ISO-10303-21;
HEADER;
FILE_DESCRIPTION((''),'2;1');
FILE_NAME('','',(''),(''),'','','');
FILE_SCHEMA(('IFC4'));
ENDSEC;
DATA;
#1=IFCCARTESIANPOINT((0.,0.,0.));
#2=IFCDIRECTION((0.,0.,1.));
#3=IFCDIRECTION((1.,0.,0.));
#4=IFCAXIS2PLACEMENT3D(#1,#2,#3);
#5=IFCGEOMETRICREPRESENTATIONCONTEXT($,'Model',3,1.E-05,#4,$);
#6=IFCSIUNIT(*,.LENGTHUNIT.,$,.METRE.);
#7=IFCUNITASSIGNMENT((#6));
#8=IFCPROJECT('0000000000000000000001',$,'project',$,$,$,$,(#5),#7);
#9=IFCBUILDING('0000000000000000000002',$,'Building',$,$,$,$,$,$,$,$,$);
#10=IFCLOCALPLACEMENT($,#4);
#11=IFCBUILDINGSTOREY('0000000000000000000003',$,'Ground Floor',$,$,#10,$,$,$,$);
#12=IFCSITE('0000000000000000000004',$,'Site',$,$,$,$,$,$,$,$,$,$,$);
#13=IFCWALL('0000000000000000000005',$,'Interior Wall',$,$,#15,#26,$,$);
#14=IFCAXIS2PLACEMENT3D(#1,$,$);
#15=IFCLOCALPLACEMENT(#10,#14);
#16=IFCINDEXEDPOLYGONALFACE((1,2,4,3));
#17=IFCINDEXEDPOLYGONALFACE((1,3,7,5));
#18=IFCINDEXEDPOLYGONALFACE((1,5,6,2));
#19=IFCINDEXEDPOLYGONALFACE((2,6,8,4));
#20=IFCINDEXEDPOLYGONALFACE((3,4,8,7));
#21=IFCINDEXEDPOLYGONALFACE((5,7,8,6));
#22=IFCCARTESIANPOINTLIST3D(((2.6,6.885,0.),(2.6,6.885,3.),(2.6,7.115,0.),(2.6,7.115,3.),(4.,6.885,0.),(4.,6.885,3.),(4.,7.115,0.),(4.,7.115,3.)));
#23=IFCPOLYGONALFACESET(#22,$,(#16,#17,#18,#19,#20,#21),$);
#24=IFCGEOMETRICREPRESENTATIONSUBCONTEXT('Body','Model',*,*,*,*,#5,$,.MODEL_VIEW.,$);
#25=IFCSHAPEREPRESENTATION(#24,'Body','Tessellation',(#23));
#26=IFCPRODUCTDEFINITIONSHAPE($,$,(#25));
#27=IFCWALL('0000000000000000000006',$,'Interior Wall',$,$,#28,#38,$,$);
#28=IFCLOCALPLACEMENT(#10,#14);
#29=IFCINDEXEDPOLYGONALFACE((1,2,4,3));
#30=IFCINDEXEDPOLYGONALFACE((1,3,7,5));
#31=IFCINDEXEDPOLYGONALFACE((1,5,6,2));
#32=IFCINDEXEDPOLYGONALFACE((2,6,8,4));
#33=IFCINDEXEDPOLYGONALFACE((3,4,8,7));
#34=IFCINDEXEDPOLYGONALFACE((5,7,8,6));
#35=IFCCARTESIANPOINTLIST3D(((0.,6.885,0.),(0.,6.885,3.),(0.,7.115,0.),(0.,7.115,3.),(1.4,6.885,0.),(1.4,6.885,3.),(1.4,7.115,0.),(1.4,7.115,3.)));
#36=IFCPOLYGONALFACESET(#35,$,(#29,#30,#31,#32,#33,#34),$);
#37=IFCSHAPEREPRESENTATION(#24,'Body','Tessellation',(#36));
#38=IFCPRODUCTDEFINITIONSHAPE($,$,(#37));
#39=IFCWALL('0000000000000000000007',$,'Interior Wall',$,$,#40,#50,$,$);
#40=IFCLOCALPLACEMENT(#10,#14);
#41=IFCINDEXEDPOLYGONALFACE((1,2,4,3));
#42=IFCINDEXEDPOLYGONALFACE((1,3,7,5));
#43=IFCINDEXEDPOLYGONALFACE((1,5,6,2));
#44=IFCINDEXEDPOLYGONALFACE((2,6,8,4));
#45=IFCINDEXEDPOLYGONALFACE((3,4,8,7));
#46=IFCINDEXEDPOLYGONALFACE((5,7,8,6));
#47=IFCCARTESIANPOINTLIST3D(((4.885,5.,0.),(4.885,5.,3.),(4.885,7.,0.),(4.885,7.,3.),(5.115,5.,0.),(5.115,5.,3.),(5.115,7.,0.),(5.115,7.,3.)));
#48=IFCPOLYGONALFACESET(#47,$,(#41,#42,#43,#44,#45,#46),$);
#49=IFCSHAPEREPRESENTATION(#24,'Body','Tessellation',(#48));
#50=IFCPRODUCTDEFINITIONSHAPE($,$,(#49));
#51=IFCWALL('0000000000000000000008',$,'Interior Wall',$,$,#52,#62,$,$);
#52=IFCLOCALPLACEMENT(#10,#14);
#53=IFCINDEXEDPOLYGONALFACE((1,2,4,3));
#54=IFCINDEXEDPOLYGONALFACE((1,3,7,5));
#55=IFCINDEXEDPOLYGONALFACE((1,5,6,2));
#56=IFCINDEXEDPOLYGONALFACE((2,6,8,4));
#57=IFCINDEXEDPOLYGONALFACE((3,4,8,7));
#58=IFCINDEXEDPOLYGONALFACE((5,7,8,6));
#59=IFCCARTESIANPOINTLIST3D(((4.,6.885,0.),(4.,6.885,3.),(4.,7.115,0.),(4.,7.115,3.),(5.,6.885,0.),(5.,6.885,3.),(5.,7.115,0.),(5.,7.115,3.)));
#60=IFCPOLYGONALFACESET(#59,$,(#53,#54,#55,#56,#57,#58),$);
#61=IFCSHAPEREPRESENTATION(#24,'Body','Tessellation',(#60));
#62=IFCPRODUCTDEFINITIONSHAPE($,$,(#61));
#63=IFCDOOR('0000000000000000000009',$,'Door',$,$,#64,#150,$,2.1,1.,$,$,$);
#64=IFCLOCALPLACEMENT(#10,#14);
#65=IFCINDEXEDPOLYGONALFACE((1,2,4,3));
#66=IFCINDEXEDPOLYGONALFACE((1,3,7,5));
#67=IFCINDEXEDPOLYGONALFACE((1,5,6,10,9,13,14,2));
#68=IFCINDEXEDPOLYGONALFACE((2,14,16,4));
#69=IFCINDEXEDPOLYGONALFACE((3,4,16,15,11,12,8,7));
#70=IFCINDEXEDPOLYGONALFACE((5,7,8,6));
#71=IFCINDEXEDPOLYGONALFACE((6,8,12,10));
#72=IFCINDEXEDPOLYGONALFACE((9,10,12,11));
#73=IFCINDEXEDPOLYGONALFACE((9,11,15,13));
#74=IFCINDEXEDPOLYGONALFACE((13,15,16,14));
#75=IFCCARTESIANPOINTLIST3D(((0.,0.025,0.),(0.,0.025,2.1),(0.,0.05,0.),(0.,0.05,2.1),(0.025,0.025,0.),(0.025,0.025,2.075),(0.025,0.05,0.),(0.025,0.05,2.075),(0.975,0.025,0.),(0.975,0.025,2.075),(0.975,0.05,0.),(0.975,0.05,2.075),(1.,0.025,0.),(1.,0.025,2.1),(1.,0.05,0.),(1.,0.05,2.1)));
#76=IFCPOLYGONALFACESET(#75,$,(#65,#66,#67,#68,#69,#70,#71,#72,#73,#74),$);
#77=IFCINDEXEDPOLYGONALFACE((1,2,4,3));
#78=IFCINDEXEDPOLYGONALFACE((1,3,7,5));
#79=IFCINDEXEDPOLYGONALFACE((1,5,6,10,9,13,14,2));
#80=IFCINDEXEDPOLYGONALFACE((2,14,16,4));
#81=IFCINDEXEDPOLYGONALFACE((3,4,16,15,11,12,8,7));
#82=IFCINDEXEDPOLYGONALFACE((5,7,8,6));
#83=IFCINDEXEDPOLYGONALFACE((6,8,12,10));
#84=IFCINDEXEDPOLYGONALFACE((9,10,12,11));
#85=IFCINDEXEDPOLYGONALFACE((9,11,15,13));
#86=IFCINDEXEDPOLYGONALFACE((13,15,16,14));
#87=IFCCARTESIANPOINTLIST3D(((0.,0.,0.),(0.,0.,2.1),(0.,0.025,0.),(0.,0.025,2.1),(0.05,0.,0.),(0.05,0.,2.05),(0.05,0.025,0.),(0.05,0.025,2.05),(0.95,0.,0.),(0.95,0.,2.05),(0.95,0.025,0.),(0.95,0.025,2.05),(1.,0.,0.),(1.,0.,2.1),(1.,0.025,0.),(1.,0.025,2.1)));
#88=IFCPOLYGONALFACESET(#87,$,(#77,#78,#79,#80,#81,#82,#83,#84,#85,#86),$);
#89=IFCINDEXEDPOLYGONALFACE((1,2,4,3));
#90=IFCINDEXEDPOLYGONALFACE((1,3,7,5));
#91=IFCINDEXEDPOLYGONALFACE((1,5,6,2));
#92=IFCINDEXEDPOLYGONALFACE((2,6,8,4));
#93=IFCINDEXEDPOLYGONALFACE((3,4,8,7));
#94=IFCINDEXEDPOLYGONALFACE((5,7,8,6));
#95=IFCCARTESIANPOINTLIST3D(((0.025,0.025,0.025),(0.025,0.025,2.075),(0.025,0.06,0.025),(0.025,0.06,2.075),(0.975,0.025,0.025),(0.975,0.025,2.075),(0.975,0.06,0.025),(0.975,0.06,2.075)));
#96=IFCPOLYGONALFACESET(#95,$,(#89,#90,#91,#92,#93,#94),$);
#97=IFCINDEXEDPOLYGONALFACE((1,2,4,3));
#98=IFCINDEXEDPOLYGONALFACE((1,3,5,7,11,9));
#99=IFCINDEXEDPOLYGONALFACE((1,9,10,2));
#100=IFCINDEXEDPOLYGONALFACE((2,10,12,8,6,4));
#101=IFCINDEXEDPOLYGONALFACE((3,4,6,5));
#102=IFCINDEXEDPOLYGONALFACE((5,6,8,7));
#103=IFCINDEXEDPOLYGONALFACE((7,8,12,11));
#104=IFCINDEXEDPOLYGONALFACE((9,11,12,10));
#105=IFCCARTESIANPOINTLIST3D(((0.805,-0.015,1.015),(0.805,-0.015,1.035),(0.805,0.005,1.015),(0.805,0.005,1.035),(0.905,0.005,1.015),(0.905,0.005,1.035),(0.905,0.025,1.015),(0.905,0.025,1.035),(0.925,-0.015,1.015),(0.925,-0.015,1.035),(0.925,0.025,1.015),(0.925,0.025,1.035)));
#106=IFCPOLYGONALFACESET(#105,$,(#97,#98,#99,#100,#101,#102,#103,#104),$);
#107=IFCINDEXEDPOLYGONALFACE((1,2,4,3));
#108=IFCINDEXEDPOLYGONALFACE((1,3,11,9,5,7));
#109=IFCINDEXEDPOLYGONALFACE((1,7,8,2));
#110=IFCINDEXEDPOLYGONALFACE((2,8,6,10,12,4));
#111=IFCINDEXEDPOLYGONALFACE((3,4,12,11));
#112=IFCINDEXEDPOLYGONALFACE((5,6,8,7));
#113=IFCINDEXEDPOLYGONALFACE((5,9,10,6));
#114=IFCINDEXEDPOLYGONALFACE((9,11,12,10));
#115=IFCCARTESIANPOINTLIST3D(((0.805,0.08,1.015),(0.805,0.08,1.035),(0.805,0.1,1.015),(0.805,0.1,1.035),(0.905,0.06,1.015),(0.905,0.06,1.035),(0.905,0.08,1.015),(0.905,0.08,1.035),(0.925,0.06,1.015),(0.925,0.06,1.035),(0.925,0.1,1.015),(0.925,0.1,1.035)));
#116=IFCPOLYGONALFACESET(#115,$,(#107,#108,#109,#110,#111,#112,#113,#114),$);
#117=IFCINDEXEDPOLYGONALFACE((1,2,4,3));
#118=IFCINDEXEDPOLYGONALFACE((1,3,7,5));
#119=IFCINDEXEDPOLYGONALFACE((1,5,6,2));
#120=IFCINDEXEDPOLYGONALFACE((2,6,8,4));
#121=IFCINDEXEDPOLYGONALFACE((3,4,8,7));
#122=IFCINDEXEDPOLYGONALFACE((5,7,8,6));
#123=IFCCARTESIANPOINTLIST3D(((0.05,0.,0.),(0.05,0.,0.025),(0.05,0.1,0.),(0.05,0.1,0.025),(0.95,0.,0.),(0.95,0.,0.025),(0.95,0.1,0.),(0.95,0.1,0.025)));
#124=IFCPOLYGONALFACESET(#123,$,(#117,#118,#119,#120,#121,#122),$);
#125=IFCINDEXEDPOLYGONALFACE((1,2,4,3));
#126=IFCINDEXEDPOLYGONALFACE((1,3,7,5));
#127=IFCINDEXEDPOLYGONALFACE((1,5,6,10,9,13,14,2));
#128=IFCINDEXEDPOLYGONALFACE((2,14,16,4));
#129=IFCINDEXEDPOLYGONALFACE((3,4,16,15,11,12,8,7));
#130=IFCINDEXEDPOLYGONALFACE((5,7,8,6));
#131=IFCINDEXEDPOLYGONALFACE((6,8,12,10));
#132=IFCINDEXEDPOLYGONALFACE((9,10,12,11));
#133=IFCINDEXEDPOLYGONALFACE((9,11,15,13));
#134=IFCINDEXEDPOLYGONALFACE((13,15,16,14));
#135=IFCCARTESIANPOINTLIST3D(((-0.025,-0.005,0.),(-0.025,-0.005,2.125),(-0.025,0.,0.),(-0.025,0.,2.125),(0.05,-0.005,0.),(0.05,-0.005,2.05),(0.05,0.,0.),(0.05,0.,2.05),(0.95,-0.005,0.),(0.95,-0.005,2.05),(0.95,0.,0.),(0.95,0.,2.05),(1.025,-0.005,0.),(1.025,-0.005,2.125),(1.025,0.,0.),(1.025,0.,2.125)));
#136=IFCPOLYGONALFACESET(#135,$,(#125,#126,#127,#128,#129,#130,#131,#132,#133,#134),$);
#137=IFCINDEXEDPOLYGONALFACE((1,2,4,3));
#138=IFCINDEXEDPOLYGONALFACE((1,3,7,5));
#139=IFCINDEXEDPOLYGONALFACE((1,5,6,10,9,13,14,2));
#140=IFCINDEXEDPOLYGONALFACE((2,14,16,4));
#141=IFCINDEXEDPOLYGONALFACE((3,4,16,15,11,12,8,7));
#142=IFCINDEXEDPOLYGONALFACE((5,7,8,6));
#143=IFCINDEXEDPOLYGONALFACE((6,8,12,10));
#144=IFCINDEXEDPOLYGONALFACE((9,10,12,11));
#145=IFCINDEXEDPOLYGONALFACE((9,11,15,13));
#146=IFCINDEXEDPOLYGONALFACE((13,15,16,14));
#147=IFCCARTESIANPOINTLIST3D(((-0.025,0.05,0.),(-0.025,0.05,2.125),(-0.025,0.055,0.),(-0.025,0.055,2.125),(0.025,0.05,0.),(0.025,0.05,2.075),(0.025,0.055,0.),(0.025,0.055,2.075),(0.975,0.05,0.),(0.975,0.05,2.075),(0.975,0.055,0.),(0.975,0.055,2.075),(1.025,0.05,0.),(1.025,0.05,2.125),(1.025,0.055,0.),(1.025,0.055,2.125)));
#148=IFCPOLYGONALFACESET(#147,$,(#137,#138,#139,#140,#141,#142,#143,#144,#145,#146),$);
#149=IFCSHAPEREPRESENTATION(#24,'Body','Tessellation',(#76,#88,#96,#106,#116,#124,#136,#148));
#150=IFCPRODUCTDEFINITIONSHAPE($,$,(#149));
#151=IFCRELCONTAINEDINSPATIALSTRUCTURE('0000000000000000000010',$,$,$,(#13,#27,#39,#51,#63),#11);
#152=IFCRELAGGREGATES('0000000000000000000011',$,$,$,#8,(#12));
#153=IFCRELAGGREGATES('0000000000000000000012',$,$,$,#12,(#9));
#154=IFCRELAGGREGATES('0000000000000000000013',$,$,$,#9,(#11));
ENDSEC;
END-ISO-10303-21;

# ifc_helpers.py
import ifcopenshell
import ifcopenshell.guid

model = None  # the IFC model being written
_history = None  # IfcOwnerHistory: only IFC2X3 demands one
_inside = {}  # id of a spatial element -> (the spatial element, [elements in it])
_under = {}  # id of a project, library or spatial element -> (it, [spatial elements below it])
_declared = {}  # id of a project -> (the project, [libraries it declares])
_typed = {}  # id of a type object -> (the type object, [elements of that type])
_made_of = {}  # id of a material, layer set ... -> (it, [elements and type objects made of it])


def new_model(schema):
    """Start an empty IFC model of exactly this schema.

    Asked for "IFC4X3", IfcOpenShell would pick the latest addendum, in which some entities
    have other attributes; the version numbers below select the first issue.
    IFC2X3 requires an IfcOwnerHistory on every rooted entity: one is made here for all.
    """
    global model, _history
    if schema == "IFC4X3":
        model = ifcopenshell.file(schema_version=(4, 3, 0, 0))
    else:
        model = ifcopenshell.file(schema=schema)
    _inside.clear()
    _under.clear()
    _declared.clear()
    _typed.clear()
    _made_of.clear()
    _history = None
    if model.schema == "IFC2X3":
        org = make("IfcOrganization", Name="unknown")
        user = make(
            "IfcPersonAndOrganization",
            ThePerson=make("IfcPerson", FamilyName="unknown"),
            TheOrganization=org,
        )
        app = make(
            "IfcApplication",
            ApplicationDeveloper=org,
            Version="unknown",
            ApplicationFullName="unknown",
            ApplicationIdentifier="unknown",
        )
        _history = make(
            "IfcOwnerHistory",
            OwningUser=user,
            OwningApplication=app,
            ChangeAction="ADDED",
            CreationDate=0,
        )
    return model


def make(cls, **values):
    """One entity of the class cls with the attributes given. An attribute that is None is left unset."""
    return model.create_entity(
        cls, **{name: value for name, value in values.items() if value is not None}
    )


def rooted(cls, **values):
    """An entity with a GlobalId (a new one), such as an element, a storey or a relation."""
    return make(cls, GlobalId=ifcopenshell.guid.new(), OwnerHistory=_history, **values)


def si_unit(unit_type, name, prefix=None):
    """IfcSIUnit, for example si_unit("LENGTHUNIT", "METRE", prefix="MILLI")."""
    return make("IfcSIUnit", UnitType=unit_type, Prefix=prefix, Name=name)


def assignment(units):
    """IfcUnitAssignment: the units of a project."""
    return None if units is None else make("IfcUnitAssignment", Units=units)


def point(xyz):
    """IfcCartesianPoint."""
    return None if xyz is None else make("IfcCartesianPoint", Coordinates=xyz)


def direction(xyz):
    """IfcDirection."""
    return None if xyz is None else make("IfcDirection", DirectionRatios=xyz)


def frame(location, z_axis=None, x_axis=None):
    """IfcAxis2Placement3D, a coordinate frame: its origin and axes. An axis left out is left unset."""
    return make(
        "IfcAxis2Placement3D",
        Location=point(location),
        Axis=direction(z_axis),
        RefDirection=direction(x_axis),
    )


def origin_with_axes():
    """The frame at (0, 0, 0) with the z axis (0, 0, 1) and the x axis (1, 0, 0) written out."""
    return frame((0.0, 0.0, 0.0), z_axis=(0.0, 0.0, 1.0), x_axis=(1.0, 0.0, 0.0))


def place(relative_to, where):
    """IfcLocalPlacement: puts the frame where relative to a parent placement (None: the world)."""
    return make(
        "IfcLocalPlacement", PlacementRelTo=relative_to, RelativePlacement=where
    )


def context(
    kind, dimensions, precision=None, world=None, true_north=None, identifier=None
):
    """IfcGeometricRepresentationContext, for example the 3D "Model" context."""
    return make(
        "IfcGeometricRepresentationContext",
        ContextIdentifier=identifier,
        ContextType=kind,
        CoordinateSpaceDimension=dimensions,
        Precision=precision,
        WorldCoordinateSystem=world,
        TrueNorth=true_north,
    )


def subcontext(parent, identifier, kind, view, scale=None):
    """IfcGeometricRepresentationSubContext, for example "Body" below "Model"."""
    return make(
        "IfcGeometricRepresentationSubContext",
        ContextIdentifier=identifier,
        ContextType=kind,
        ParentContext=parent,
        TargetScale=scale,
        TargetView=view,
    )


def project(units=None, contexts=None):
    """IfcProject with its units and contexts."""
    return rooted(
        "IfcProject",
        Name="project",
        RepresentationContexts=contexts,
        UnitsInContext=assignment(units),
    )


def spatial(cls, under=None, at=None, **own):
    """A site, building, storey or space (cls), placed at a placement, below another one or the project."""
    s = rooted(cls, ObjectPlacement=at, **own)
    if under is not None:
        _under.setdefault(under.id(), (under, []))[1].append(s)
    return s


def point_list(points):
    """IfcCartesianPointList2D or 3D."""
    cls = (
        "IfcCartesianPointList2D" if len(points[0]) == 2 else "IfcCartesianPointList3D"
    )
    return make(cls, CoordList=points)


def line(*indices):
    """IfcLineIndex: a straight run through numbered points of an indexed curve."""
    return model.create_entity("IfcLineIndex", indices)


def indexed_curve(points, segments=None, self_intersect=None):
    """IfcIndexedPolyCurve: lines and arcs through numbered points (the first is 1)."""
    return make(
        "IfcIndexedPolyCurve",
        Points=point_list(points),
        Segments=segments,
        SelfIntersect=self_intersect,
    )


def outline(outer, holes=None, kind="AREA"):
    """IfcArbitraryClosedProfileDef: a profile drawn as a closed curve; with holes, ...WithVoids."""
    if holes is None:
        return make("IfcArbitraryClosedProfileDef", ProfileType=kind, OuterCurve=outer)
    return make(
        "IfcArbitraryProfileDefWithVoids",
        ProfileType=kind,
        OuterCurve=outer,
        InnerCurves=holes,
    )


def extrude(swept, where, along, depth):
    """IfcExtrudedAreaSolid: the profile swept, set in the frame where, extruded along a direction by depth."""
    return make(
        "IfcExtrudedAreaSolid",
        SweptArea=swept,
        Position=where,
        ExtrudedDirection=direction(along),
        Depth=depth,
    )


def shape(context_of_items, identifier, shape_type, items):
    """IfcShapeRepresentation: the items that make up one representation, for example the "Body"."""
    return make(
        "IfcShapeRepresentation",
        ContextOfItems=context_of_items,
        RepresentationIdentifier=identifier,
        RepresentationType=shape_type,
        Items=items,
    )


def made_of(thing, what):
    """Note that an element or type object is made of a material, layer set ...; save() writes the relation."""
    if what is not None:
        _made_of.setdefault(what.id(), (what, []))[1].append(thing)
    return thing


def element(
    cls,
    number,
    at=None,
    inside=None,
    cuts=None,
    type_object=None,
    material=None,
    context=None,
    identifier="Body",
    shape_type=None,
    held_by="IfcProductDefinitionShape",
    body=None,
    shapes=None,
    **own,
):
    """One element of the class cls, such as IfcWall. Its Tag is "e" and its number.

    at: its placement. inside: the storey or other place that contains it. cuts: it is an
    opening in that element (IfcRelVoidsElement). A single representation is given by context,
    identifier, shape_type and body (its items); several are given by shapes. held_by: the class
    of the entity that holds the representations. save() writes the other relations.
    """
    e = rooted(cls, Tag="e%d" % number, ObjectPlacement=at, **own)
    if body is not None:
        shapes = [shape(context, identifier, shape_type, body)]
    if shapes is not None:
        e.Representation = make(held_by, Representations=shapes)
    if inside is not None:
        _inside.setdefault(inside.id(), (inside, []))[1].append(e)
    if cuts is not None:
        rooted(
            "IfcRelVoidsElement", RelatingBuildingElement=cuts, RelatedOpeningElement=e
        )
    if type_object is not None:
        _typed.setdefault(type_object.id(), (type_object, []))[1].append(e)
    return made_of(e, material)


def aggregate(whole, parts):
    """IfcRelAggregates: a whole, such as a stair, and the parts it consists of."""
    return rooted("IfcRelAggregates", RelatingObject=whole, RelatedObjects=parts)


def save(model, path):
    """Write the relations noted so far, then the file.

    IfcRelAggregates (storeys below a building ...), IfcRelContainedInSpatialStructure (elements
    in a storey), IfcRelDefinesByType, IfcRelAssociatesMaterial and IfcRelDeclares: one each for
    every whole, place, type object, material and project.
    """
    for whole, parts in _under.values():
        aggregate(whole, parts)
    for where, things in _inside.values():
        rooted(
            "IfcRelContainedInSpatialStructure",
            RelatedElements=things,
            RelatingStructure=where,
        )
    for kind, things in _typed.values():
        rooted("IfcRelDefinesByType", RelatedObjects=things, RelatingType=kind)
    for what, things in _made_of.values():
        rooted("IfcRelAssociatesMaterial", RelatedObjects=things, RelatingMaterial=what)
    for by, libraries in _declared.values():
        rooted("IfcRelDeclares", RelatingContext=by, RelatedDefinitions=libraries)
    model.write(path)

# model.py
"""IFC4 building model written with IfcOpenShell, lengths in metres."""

from ifc_helpers import new_model, si_unit, frame, origin_with_axes, place, context, subcontext, project, spatial, line, indexed_curve, outline, extrude, element, save


model = new_model("IFC4")

# Units and contexts
model_context = context("Model", 3, precision=1e-05, world=origin_with_axes())
body_context = subcontext(model_context, "Body", "Model", "MODEL_VIEW")
ifc_project = project(units=[si_unit("LENGTHUNIT", "METRE")], contexts=[model_context])

# Site, building, storey
site = spatial("IfcSite", under=ifc_project, Name="Site")
building = spatial("IfcBuilding", under=site, Name="Building")
storey_placement = place(None, origin_with_axes())
storey = spatial("IfcBuildingStorey", under=building, at=storey_placement, Name="Ground Floor")

# Walls
for number, where, z_axis, x_axis, name in (
    (1, (4.0, 7.0, 0.0), (0.0, 0.0, 1.0), (-1.0, 0.0, 0.0), "Interior Wall"),
    (2, (1.4, 7.0, 0.0), (0.0, 0.0, 1.0), (-1.0, 0.0, 0.0), "Interior Wall"),
):
    element("IfcWall", number, at=place(storey_placement, frame(where, z_axis=z_axis, x_axis=x_axis)), inside=storey, Name=name, context=body_context, shape_type="SweptSolid", body=[
        extrude(outline(indexed_curve([(0.0, 0.0), (0.0, 0.23), (1.4, 0.23), (1.4, 0.0), (0.0, 0.0)], self_intersect=False)), frame((0.0, -0.115, 0.0), z_axis=(0.0, 0.0, 1.0), x_axis=(1.0, 0.0, 0.0)), (0.0, 0.0, 1.0), 3.0),
    ])
wall_1_placement = place(storey_placement, frame((5.0, 5.0, 0.0), z_axis=(0.0, 0.0, 1.0), x_axis=(0.0, 1.0, 0.0)))
element("IfcWall", 3, at=wall_1_placement, inside=storey, Name="Interior Wall", context=body_context, shape_type="SweptSolid", body=[
    extrude(outline(indexed_curve([(0.0, 0.0), (0.0, 0.23), (2.0, 0.23), (2.0, 0.0), (0.0, 0.0)], self_intersect=False)), frame((0.0, -0.115, 0.0), z_axis=(0.0, 0.0, 1.0), x_axis=(1.0, 0.0, 0.0)), (0.0, 0.0, 1.0), 3.0),
])
wall_2_placement = place(storey_placement, frame((5.0, 7.0, 0.0), z_axis=(0.0, 0.0, 1.0), x_axis=(-1.0, 0.0, 0.0)))
element("IfcWall", 4, at=wall_2_placement, inside=storey, Name="Interior Wall", context=body_context, shape_type="SweptSolid", body=[
    extrude(outline(indexed_curve([(0.0, 0.0), (0.0, 0.23), (1.0, 0.23), (1.0, 0.0), (0.0, 0.0)], self_intersect=False)), frame((0.0, -0.115, 0.0), z_axis=(0.0, 0.0, 1.0), x_axis=(1.0, 0.0, 0.0)), (0.0, 0.0, 1.0), 3.0),
])

# Door
door_1_placement = place(storey_placement, origin_with_axes())
element("IfcDoor", 5, at=door_1_placement, inside=storey, Name="Door", OverallHeight=2.1, OverallWidth=1.0, context=body_context, shape_type="SweptSolid", body=[
    extrude(outline(indexed_curve([(0.0, 0.0), (0.0, 2.1), (1.0, 2.1), (1.0, 0.0), (0.975, 0.0), (0.975, 2.075), (0.025, 2.075), (0.025, 0.0)], segments=[line(1, 2, 3, 4, 5, 6, 7, 8, 1)])), frame((0.0, 0.025, 0.0), z_axis=(0.0, -1.0, 0.0), x_axis=(1.0, 0.0, 0.0)), (0.0, 0.0, -1.0), 0.025),
    extrude(outline(indexed_curve([(0.0, 0.0), (0.0, 2.1), (1.0, 2.1), (1.0, 0.0), (0.95, 0.0), (0.95, 2.05), (0.05, 2.05), (0.05, 0.0)], segments=[line(1, 2, 3, 4, 5, 6, 7, 8, 1)])), frame((0.0, 0.0, 0.0), z_axis=(0.0, -1.0, 0.0), x_axis=(1.0, 0.0, 0.0)), (0.0, 0.0, -1.0), 0.025),
    extrude(outline(indexed_curve([(0.0, 0.0), (0.95, 0.0), (0.95, 0.035), (0.0, 0.035)], segments=[line(1, 2, 3, 4, 1)])), frame((0.025, 0.025, 0.025), z_axis=(0.0, 0.0, 1.0), x_axis=(1.0, 0.0, 0.0)), (0.0, 0.0, 1.0), 2.05),
    extrude(outline(indexed_curve([(0.0, 0.0), (0.0, -0.04), (-0.12, -0.04), (-0.12, -0.02), (-0.02, -0.02), (-0.02, 0.0)], segments=[line(1, 2, 3, 4, 5, 6, 1)])), frame((0.925, 0.025, 1.015), z_axis=(0.0, 0.0, 1.0), x_axis=(1.0, 0.0, 0.0)), (0.0, 0.0, 1.0), 0.02),
    extrude(outline(indexed_curve([(0.0, 0.0), (0.0, 0.04), (-0.12, 0.04), (-0.12, 0.02), (-0.02, 0.02), (-0.02, 0.0)], segments=[line(1, 2, 3, 4, 5, 6, 1)])), frame((0.925, 0.06, 1.015), z_axis=(0.0, 0.0, 1.0), x_axis=(1.0, 0.0, 0.0)), (0.0, 0.0, 1.0), 0.02),
    extrude(outline(indexed_curve([(0.0, 0.0), (0.9, 0.0), (0.9, 0.1), (0.0, 0.1)], segments=[line(1, 2, 3, 4, 1)])), frame((0.05, 0.0, 0.0), z_axis=(0.0, 0.0, 1.0), x_axis=(1.0, 0.0, 0.0)), (0.0, 0.0, 1.0), 0.025),
    extrude(outline(indexed_curve([(0.0, 0.0), (0.0, 2.125), (1.05, 2.125), (1.05, 0.0), (0.975, 0.0), (0.975, 2.05), (0.075, 2.05), (0.075, 0.0)], segments=[line(1, 2, 3, 4, 5, 6, 7, 8, 1)])), frame((-0.025, -0.005, 0.0), z_axis=(0.0, -1.0, 0.0), x_axis=(1.0, 0.0, 0.0)), (0.0, 0.0, -1.0), 0.005),
    extrude(outline(indexed_curve([(0.0, 0.0), (0.0, 2.125), (1.05, 2.125), (1.05, 0.0), (1.0, 0.0), (1.0, 2.075), (0.05, 2.075), (0.05, 0.0)], segments=[line(1, 2, 3, 4, 5, 6, 7, 8, 1)])), frame((-0.025, 0.05, 0.0), z_axis=(0.0, -1.0, 0.0), x_axis=(1.0, 0.0, 0.0)), (0.0, 0.0, -1.0), 0.005),
])

save(model, "model.ifc")
